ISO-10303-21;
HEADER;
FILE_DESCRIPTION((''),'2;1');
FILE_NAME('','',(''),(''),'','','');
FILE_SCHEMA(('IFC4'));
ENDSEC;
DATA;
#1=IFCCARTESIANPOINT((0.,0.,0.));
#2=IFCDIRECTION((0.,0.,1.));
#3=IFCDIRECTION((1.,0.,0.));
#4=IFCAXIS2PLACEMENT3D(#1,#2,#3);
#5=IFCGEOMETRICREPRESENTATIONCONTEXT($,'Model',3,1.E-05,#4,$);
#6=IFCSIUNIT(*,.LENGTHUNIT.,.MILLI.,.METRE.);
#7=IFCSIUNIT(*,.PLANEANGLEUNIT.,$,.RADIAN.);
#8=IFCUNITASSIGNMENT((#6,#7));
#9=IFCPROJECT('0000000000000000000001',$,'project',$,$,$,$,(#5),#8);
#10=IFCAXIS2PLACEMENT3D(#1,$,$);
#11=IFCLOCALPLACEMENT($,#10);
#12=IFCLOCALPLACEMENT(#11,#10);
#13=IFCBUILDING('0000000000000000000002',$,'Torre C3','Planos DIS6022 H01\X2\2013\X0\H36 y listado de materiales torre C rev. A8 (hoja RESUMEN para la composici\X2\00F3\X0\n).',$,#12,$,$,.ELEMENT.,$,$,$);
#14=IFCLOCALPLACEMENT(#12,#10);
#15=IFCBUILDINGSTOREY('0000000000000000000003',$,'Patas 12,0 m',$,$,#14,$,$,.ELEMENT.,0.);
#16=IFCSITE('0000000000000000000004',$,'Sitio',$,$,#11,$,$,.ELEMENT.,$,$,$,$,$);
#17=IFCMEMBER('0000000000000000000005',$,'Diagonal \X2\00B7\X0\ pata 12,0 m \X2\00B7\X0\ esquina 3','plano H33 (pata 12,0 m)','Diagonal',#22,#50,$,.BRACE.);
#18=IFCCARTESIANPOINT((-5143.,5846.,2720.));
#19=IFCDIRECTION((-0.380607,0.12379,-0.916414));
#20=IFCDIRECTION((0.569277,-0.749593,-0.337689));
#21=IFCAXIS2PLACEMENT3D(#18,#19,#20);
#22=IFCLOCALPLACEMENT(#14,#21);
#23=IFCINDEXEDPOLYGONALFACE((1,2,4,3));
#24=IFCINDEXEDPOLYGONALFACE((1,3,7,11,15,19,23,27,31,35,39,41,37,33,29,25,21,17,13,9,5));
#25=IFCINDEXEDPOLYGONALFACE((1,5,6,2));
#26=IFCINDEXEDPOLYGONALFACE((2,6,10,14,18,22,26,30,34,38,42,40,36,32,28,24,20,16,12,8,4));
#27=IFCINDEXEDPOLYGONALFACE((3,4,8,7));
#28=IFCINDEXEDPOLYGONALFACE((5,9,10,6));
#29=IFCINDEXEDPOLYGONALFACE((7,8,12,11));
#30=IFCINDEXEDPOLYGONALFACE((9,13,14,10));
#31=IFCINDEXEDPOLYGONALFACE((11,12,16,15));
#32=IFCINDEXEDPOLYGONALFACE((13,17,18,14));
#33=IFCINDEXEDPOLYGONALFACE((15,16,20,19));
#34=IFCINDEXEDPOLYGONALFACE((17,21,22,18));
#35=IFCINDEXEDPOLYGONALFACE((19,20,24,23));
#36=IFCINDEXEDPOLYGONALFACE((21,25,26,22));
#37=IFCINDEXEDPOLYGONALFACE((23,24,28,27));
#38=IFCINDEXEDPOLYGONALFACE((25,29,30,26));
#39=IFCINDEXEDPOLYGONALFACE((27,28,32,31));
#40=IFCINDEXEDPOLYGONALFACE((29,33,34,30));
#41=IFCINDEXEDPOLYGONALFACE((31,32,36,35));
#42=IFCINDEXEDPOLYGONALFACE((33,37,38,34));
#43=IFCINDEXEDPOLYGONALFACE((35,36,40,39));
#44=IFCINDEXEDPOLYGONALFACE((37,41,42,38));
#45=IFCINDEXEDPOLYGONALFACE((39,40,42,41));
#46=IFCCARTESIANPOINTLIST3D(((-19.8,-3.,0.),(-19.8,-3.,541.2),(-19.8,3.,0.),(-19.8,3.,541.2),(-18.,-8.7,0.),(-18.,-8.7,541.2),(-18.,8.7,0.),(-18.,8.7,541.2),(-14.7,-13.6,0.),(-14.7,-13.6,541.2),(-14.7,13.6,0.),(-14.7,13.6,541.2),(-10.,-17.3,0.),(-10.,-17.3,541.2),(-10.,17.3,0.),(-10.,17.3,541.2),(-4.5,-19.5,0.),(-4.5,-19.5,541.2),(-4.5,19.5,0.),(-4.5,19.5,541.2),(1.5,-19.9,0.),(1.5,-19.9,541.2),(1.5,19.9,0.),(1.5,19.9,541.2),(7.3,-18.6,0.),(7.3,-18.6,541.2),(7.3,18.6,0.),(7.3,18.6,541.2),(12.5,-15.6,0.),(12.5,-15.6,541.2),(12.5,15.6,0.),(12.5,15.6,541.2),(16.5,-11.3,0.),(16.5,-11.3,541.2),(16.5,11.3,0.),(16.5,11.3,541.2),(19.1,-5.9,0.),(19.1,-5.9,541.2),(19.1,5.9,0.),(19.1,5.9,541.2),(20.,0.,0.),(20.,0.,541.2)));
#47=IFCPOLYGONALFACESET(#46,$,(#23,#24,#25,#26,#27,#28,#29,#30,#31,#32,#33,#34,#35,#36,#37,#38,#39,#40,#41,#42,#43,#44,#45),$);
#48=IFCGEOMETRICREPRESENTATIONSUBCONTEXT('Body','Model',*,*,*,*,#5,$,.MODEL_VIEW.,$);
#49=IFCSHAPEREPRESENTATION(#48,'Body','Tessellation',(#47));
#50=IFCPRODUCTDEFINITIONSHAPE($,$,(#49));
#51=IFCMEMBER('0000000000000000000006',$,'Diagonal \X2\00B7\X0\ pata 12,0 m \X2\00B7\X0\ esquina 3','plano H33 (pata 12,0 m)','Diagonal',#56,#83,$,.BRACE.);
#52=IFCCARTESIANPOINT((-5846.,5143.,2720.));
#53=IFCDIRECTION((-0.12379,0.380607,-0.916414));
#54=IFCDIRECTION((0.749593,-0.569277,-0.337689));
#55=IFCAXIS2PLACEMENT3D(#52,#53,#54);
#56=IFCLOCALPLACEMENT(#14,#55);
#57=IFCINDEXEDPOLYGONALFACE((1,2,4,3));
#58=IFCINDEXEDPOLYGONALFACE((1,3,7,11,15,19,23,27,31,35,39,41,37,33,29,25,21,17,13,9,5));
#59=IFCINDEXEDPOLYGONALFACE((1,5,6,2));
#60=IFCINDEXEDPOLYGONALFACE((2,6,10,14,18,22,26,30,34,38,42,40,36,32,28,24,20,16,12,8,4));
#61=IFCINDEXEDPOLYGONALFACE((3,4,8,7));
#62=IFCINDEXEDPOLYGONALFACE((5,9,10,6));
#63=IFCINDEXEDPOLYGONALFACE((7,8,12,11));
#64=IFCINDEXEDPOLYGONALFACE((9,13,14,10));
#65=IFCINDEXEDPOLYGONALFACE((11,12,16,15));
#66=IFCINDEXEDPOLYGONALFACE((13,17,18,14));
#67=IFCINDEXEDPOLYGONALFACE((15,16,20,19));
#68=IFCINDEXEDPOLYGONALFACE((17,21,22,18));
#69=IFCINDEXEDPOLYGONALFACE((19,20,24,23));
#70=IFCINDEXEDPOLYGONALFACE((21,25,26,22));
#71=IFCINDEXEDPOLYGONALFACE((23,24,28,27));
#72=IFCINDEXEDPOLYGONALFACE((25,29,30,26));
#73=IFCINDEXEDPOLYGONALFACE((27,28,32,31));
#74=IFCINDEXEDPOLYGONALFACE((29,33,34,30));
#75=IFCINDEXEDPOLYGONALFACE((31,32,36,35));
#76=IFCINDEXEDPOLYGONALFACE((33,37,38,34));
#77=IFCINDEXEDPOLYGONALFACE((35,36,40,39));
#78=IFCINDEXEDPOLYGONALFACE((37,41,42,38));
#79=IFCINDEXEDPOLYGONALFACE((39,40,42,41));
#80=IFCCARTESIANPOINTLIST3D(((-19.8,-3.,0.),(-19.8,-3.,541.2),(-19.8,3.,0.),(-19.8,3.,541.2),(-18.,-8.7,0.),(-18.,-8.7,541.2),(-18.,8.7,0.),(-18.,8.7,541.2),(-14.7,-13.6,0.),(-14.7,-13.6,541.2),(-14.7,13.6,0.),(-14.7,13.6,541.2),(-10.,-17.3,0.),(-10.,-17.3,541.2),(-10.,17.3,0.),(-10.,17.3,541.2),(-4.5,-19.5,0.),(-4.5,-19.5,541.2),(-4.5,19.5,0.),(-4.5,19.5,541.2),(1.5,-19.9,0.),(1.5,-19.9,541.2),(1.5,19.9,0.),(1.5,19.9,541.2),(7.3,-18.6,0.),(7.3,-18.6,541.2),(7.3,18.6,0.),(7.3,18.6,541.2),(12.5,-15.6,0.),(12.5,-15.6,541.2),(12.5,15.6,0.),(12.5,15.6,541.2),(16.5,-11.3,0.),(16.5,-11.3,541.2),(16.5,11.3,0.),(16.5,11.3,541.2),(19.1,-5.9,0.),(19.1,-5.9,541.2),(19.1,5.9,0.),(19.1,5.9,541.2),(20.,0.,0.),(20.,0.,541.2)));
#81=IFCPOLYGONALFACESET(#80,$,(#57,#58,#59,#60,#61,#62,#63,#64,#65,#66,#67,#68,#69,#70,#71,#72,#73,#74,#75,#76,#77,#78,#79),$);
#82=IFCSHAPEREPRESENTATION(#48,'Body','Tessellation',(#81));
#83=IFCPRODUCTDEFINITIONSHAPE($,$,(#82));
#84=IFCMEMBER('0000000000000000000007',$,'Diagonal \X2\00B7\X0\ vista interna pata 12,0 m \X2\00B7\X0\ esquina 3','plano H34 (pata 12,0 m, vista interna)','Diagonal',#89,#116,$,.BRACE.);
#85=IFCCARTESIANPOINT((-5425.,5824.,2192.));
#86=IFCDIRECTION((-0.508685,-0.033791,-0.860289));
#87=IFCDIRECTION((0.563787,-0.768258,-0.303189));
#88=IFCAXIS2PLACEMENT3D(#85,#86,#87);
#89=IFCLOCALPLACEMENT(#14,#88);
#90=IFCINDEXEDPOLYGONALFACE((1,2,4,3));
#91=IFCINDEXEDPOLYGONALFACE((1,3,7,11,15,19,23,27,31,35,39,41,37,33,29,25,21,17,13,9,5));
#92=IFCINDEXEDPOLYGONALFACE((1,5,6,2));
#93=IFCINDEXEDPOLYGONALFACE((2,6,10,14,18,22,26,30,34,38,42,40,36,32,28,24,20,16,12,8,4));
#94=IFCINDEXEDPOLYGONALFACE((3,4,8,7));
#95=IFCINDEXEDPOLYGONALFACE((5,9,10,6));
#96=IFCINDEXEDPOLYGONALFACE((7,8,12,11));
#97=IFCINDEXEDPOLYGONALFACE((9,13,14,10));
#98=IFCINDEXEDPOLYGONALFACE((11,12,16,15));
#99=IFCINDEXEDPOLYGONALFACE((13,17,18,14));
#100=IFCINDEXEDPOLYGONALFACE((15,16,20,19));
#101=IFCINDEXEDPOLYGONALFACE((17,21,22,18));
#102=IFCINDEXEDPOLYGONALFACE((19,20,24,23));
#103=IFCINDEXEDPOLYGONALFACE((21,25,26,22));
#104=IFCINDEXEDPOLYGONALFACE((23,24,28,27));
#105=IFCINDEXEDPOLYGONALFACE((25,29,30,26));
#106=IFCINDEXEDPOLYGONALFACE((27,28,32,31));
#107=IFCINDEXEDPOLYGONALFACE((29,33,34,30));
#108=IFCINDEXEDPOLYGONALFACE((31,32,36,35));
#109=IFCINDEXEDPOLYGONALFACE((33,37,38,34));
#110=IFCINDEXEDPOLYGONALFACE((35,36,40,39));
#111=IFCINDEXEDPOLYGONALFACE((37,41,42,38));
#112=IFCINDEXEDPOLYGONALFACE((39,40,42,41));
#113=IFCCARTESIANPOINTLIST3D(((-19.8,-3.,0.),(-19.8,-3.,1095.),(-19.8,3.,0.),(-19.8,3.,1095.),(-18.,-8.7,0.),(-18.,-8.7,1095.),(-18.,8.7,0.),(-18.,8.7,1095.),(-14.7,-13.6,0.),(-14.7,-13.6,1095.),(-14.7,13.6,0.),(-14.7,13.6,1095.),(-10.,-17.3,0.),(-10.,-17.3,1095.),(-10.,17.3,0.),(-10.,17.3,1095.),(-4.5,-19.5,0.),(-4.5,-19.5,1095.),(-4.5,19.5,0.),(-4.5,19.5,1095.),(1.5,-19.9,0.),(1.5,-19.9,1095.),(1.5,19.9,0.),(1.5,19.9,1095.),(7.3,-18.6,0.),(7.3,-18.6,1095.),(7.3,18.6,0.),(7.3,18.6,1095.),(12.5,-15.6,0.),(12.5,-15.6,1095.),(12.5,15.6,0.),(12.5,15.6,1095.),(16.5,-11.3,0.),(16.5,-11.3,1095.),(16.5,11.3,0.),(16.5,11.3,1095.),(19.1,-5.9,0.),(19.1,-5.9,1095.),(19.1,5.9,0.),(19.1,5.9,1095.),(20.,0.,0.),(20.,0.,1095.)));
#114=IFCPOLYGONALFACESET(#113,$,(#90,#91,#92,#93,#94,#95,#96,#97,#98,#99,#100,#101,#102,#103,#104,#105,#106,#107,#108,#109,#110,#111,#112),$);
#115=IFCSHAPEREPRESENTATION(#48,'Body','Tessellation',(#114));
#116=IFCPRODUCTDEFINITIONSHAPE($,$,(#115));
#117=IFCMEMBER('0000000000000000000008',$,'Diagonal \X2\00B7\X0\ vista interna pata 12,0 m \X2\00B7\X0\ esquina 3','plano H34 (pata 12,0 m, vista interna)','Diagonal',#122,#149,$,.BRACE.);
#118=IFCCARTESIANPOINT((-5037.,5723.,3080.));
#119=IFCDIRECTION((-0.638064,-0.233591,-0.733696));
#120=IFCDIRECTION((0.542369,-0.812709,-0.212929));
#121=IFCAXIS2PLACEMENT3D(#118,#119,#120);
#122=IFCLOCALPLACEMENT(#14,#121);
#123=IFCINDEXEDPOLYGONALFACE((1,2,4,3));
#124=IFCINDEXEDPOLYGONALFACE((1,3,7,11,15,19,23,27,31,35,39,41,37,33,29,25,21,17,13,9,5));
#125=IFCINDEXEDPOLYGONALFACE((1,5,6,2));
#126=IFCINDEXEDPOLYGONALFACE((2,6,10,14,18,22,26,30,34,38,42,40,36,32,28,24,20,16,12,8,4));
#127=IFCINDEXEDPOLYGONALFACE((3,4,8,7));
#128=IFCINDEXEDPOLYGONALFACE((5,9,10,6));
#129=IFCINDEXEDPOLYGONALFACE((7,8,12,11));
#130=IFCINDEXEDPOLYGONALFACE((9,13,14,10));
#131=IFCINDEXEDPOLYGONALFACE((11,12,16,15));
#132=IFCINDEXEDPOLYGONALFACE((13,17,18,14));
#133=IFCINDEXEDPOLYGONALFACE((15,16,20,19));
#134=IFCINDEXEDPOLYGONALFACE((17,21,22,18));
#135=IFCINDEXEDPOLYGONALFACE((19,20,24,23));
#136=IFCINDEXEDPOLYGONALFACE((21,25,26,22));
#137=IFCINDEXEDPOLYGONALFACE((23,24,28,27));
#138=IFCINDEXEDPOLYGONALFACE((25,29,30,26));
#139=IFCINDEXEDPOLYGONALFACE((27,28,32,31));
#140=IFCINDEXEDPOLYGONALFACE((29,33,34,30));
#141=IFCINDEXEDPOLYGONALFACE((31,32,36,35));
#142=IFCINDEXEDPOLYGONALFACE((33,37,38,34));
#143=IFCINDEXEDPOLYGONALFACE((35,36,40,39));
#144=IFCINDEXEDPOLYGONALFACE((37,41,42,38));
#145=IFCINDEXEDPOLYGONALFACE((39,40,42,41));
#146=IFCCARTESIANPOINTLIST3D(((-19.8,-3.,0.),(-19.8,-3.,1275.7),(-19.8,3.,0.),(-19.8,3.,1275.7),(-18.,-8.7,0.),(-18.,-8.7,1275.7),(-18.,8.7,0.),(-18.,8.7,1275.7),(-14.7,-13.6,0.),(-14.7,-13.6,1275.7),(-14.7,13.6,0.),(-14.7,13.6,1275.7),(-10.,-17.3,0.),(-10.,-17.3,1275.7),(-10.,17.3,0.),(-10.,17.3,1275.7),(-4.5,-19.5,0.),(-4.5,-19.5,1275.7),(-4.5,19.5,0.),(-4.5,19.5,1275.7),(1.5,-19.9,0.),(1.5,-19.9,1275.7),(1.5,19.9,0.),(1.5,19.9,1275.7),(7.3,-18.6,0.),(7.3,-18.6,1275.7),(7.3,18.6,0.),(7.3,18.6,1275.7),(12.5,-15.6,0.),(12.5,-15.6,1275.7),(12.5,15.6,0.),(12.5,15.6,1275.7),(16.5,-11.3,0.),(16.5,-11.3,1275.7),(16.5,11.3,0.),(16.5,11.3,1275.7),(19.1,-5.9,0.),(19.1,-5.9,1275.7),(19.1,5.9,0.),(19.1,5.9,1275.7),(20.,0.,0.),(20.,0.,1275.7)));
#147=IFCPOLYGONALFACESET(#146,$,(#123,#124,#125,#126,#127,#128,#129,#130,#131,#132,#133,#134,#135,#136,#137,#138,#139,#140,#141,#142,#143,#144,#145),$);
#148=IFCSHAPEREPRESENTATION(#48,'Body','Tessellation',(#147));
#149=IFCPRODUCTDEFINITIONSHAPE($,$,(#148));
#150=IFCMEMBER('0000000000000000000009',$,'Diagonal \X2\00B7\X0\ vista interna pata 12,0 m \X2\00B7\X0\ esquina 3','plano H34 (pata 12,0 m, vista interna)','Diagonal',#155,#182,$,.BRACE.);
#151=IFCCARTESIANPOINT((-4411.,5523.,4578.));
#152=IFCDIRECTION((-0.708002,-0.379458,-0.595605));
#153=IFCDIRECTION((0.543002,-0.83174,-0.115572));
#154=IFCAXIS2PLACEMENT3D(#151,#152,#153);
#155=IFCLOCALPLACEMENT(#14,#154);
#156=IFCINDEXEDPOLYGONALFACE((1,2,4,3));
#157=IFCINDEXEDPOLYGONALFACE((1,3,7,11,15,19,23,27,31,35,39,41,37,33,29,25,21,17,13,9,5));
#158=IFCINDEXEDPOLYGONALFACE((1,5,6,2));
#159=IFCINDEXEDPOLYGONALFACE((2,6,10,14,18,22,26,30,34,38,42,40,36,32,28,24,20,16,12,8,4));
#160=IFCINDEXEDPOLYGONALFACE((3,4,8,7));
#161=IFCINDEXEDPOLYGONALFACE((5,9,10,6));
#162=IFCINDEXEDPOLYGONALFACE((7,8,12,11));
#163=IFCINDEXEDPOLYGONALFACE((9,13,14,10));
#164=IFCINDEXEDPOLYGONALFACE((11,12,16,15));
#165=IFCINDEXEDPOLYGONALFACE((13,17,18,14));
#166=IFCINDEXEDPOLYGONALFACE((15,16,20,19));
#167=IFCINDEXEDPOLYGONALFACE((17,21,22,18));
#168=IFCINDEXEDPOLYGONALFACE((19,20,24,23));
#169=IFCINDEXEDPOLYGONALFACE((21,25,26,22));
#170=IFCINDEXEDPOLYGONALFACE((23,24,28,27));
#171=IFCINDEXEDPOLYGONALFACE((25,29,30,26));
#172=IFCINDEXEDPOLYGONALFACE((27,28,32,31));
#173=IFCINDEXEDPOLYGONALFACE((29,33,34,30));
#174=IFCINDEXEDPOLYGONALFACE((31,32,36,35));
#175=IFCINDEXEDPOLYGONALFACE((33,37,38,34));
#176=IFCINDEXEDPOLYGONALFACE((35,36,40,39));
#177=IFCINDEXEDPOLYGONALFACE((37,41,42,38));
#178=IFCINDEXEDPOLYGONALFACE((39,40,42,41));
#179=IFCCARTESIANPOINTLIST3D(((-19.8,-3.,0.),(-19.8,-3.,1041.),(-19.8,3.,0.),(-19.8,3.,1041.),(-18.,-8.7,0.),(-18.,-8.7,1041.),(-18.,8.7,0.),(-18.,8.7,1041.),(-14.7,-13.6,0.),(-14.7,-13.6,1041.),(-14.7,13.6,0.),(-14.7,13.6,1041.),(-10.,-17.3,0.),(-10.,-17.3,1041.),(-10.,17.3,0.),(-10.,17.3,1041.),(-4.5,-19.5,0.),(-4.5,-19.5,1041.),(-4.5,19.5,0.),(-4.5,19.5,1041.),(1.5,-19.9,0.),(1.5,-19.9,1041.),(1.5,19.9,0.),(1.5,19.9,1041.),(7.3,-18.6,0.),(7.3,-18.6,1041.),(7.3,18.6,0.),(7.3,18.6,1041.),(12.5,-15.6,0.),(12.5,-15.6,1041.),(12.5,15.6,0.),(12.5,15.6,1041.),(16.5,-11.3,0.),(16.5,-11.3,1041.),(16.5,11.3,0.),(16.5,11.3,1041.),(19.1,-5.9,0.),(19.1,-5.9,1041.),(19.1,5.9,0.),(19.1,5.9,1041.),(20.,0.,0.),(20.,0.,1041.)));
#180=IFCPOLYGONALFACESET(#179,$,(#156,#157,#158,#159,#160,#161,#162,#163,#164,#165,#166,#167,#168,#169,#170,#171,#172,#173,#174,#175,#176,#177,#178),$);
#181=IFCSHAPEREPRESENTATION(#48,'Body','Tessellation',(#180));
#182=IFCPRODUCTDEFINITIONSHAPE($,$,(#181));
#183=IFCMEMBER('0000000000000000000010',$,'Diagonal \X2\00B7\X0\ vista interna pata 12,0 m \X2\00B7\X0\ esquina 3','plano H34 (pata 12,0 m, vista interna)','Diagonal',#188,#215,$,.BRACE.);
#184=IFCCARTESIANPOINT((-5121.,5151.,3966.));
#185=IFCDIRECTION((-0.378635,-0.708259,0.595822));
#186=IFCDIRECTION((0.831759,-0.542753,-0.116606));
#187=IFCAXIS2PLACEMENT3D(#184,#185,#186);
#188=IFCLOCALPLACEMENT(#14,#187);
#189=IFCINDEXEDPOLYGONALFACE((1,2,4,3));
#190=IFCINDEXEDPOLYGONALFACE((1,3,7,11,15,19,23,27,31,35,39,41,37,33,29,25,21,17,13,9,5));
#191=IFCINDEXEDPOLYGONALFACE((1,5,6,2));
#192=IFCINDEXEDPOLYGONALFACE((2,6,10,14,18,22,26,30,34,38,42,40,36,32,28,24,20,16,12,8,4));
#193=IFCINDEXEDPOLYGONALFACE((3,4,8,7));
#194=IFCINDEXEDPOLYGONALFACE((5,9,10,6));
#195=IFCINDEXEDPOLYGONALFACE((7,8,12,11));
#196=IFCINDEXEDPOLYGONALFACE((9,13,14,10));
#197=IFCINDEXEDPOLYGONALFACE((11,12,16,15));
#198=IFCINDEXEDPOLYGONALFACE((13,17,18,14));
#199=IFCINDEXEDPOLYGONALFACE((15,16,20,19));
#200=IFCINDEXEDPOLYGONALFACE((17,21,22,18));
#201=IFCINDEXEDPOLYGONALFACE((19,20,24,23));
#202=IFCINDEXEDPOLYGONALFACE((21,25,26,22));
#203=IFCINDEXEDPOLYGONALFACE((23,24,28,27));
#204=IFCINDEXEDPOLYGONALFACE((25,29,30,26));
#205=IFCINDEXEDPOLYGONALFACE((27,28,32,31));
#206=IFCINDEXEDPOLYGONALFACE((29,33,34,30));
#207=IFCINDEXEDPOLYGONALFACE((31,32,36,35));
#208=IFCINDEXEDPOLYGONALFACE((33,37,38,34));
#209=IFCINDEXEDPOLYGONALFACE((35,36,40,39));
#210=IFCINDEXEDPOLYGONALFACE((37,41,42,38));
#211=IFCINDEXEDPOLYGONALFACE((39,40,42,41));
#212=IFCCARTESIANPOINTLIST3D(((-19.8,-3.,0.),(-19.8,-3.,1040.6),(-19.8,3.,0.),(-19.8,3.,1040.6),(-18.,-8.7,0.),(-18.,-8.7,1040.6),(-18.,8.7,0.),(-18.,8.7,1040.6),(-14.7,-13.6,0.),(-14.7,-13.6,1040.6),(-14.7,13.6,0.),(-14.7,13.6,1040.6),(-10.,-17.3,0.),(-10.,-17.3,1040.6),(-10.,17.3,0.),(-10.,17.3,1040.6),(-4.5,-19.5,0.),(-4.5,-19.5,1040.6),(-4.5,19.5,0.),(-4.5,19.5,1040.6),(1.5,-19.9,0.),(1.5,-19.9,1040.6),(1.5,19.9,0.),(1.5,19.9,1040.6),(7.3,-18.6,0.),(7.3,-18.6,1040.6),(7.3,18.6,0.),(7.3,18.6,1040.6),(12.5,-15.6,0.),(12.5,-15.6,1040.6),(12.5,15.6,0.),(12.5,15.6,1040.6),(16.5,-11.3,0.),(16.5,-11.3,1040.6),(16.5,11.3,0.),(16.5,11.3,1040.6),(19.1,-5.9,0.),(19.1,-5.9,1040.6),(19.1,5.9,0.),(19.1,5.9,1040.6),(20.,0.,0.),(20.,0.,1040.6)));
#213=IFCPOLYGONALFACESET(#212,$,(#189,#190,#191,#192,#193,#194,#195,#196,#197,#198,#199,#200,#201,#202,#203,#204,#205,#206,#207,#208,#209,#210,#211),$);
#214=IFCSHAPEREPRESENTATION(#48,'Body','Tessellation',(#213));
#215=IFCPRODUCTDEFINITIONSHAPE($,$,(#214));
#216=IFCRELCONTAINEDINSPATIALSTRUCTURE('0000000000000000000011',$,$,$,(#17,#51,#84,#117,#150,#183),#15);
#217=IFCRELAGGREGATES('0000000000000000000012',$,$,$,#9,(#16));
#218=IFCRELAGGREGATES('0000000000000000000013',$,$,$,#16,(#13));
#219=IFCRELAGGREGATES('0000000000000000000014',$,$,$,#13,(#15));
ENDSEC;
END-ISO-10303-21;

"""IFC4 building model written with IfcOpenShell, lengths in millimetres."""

from ifc_helpers import new_model, si_unit, frame, origin, origin_with_axes, place, context, subcontext, project, spatial, circle, extrude, element, save


model = new_model("IFC4")

# Units and contexts
model_context = context("Model", 3, precision=1e-05, world=origin_with_axes())
body_context = subcontext(model_context, "Body", "Model", "MODEL_VIEW")
ifc_project = project(units=[si_unit("LENGTHUNIT", "METRE", prefix="MILLI"), si_unit("PLANEANGLEUNIT", "RADIAN")], contexts=[model_context])

# Site, building, storey
site_placement = place(None, origin())
site = spatial("IfcSite", under=ifc_project, at=site_placement, Name="Sitio", CompositionType="ELEMENT")
building_placement = place(site_placement, origin())
building = spatial("IfcBuilding", under=site, at=building_placement, Name="Torre C3", Description="Planos DIS6022 H01–H36 y listado de materiales torre C rev. A8 (hoja RESUMEN para la composición).", CompositionType="ELEMENT")
storey_placement = place(building_placement, origin())
storey = spatial("IfcBuildingStorey", under=building, at=storey_placement, Name="Patas 12,0 m", CompositionType="ELEMENT", Elevation=0.0)

# Members
for number, where, z_axis, x_axis, name in (
    (1, (-5143.0, 5846.0, 2720.0), (-0.380607, 0.12379, -0.916414), (0.569277, -0.749593, -0.337689), "Diagonal · pata 12,0 m · esquina 3"),
    (2, (-5846.0, 5143.0, 2720.0), (-0.12379, 0.380607, -0.916414), (0.749593, -0.569277, -0.337689), "Diagonal · pata 12,0 m · esquina 3"),
):
    element("IfcMember", number, at=place(storey_placement, frame(where, z_axis=z_axis, x_axis=x_axis)), inside=storey, Name=name, Description="plano H33 (pata 12,0 m)", ObjectType="Diagonal", PredefinedType="BRACE", context=body_context, shape_type="SweptSolid", body=[
        extrude(circle(Radius=20.0), None, (0.0, 0.0, 1.0), 541.2),
    ])
member_1_placement = place(storey_placement, frame((-5425.0, 5824.0, 2192.0), z_axis=(-0.508685, -0.033791, -0.860289), x_axis=(0.563787, -0.768258, -0.303189)))
element("IfcMember", 3, at=member_1_placement, inside=storey, Name="Diagonal · vista interna pata 12,0 m · esquina 3", Description="plano H34 (pata 12,0 m, vista interna)", ObjectType="Diagonal", PredefinedType="BRACE", context=body_context, shape_type="SweptSolid", body=[
    extrude(circle(Radius=20.0), None, (0.0, 0.0, 1.0), 1095.0),
])
member_2_placement = place(storey_placement, frame((-5037.0, 5723.0, 3080.0), z_axis=(-0.638064, -0.233591, -0.733696), x_axis=(0.542369, -0.812709, -0.212929)))
element("IfcMember", 4, at=member_2_placement, inside=storey, Name="Diagonal · vista interna pata 12,0 m · esquina 3", Description="plano H34 (pata 12,0 m, vista interna)", ObjectType="Diagonal", PredefinedType="BRACE", context=body_context, shape_type="SweptSolid", body=[
    extrude(circle(Radius=20.0), None, (0.0, 0.0, 1.0), 1275.7),
])
member_3_placement = place(storey_placement, frame((-4411.0, 5523.0, 4578.0), z_axis=(-0.708002, -0.379458, -0.595605), x_axis=(0.543002, -0.83174, -0.115572)))
element("IfcMember", 5, at=member_3_placement, inside=storey, Name="Diagonal · vista interna pata 12,0 m · esquina 3", Description="plano H34 (pata 12,0 m, vista interna)", ObjectType="Diagonal", PredefinedType="BRACE", context=body_context, shape_type="SweptSolid", body=[
    extrude(circle(Radius=20.0), None, (0.0, 0.0, 1.0), 1041.0),
])
member_4_placement = place(storey_placement, frame((-5121.0, 5151.0, 3966.0), z_axis=(-0.378635, -0.708259, 0.595822), x_axis=(0.831759, -0.542753, -0.116606)))
element("IfcMember", 6, at=member_4_placement, inside=storey, Name="Diagonal · vista interna pata 12,0 m · esquina 3", Description="plano H34 (pata 12,0 m, vista interna)", ObjectType="Diagonal", PredefinedType="BRACE", context=body_context, shape_type="SweptSolid", body=[
    extrude(circle(Radius=20.0), None, (0.0, 0.0, 1.0), 1040.6),
])

save(model, "model.ifc")
